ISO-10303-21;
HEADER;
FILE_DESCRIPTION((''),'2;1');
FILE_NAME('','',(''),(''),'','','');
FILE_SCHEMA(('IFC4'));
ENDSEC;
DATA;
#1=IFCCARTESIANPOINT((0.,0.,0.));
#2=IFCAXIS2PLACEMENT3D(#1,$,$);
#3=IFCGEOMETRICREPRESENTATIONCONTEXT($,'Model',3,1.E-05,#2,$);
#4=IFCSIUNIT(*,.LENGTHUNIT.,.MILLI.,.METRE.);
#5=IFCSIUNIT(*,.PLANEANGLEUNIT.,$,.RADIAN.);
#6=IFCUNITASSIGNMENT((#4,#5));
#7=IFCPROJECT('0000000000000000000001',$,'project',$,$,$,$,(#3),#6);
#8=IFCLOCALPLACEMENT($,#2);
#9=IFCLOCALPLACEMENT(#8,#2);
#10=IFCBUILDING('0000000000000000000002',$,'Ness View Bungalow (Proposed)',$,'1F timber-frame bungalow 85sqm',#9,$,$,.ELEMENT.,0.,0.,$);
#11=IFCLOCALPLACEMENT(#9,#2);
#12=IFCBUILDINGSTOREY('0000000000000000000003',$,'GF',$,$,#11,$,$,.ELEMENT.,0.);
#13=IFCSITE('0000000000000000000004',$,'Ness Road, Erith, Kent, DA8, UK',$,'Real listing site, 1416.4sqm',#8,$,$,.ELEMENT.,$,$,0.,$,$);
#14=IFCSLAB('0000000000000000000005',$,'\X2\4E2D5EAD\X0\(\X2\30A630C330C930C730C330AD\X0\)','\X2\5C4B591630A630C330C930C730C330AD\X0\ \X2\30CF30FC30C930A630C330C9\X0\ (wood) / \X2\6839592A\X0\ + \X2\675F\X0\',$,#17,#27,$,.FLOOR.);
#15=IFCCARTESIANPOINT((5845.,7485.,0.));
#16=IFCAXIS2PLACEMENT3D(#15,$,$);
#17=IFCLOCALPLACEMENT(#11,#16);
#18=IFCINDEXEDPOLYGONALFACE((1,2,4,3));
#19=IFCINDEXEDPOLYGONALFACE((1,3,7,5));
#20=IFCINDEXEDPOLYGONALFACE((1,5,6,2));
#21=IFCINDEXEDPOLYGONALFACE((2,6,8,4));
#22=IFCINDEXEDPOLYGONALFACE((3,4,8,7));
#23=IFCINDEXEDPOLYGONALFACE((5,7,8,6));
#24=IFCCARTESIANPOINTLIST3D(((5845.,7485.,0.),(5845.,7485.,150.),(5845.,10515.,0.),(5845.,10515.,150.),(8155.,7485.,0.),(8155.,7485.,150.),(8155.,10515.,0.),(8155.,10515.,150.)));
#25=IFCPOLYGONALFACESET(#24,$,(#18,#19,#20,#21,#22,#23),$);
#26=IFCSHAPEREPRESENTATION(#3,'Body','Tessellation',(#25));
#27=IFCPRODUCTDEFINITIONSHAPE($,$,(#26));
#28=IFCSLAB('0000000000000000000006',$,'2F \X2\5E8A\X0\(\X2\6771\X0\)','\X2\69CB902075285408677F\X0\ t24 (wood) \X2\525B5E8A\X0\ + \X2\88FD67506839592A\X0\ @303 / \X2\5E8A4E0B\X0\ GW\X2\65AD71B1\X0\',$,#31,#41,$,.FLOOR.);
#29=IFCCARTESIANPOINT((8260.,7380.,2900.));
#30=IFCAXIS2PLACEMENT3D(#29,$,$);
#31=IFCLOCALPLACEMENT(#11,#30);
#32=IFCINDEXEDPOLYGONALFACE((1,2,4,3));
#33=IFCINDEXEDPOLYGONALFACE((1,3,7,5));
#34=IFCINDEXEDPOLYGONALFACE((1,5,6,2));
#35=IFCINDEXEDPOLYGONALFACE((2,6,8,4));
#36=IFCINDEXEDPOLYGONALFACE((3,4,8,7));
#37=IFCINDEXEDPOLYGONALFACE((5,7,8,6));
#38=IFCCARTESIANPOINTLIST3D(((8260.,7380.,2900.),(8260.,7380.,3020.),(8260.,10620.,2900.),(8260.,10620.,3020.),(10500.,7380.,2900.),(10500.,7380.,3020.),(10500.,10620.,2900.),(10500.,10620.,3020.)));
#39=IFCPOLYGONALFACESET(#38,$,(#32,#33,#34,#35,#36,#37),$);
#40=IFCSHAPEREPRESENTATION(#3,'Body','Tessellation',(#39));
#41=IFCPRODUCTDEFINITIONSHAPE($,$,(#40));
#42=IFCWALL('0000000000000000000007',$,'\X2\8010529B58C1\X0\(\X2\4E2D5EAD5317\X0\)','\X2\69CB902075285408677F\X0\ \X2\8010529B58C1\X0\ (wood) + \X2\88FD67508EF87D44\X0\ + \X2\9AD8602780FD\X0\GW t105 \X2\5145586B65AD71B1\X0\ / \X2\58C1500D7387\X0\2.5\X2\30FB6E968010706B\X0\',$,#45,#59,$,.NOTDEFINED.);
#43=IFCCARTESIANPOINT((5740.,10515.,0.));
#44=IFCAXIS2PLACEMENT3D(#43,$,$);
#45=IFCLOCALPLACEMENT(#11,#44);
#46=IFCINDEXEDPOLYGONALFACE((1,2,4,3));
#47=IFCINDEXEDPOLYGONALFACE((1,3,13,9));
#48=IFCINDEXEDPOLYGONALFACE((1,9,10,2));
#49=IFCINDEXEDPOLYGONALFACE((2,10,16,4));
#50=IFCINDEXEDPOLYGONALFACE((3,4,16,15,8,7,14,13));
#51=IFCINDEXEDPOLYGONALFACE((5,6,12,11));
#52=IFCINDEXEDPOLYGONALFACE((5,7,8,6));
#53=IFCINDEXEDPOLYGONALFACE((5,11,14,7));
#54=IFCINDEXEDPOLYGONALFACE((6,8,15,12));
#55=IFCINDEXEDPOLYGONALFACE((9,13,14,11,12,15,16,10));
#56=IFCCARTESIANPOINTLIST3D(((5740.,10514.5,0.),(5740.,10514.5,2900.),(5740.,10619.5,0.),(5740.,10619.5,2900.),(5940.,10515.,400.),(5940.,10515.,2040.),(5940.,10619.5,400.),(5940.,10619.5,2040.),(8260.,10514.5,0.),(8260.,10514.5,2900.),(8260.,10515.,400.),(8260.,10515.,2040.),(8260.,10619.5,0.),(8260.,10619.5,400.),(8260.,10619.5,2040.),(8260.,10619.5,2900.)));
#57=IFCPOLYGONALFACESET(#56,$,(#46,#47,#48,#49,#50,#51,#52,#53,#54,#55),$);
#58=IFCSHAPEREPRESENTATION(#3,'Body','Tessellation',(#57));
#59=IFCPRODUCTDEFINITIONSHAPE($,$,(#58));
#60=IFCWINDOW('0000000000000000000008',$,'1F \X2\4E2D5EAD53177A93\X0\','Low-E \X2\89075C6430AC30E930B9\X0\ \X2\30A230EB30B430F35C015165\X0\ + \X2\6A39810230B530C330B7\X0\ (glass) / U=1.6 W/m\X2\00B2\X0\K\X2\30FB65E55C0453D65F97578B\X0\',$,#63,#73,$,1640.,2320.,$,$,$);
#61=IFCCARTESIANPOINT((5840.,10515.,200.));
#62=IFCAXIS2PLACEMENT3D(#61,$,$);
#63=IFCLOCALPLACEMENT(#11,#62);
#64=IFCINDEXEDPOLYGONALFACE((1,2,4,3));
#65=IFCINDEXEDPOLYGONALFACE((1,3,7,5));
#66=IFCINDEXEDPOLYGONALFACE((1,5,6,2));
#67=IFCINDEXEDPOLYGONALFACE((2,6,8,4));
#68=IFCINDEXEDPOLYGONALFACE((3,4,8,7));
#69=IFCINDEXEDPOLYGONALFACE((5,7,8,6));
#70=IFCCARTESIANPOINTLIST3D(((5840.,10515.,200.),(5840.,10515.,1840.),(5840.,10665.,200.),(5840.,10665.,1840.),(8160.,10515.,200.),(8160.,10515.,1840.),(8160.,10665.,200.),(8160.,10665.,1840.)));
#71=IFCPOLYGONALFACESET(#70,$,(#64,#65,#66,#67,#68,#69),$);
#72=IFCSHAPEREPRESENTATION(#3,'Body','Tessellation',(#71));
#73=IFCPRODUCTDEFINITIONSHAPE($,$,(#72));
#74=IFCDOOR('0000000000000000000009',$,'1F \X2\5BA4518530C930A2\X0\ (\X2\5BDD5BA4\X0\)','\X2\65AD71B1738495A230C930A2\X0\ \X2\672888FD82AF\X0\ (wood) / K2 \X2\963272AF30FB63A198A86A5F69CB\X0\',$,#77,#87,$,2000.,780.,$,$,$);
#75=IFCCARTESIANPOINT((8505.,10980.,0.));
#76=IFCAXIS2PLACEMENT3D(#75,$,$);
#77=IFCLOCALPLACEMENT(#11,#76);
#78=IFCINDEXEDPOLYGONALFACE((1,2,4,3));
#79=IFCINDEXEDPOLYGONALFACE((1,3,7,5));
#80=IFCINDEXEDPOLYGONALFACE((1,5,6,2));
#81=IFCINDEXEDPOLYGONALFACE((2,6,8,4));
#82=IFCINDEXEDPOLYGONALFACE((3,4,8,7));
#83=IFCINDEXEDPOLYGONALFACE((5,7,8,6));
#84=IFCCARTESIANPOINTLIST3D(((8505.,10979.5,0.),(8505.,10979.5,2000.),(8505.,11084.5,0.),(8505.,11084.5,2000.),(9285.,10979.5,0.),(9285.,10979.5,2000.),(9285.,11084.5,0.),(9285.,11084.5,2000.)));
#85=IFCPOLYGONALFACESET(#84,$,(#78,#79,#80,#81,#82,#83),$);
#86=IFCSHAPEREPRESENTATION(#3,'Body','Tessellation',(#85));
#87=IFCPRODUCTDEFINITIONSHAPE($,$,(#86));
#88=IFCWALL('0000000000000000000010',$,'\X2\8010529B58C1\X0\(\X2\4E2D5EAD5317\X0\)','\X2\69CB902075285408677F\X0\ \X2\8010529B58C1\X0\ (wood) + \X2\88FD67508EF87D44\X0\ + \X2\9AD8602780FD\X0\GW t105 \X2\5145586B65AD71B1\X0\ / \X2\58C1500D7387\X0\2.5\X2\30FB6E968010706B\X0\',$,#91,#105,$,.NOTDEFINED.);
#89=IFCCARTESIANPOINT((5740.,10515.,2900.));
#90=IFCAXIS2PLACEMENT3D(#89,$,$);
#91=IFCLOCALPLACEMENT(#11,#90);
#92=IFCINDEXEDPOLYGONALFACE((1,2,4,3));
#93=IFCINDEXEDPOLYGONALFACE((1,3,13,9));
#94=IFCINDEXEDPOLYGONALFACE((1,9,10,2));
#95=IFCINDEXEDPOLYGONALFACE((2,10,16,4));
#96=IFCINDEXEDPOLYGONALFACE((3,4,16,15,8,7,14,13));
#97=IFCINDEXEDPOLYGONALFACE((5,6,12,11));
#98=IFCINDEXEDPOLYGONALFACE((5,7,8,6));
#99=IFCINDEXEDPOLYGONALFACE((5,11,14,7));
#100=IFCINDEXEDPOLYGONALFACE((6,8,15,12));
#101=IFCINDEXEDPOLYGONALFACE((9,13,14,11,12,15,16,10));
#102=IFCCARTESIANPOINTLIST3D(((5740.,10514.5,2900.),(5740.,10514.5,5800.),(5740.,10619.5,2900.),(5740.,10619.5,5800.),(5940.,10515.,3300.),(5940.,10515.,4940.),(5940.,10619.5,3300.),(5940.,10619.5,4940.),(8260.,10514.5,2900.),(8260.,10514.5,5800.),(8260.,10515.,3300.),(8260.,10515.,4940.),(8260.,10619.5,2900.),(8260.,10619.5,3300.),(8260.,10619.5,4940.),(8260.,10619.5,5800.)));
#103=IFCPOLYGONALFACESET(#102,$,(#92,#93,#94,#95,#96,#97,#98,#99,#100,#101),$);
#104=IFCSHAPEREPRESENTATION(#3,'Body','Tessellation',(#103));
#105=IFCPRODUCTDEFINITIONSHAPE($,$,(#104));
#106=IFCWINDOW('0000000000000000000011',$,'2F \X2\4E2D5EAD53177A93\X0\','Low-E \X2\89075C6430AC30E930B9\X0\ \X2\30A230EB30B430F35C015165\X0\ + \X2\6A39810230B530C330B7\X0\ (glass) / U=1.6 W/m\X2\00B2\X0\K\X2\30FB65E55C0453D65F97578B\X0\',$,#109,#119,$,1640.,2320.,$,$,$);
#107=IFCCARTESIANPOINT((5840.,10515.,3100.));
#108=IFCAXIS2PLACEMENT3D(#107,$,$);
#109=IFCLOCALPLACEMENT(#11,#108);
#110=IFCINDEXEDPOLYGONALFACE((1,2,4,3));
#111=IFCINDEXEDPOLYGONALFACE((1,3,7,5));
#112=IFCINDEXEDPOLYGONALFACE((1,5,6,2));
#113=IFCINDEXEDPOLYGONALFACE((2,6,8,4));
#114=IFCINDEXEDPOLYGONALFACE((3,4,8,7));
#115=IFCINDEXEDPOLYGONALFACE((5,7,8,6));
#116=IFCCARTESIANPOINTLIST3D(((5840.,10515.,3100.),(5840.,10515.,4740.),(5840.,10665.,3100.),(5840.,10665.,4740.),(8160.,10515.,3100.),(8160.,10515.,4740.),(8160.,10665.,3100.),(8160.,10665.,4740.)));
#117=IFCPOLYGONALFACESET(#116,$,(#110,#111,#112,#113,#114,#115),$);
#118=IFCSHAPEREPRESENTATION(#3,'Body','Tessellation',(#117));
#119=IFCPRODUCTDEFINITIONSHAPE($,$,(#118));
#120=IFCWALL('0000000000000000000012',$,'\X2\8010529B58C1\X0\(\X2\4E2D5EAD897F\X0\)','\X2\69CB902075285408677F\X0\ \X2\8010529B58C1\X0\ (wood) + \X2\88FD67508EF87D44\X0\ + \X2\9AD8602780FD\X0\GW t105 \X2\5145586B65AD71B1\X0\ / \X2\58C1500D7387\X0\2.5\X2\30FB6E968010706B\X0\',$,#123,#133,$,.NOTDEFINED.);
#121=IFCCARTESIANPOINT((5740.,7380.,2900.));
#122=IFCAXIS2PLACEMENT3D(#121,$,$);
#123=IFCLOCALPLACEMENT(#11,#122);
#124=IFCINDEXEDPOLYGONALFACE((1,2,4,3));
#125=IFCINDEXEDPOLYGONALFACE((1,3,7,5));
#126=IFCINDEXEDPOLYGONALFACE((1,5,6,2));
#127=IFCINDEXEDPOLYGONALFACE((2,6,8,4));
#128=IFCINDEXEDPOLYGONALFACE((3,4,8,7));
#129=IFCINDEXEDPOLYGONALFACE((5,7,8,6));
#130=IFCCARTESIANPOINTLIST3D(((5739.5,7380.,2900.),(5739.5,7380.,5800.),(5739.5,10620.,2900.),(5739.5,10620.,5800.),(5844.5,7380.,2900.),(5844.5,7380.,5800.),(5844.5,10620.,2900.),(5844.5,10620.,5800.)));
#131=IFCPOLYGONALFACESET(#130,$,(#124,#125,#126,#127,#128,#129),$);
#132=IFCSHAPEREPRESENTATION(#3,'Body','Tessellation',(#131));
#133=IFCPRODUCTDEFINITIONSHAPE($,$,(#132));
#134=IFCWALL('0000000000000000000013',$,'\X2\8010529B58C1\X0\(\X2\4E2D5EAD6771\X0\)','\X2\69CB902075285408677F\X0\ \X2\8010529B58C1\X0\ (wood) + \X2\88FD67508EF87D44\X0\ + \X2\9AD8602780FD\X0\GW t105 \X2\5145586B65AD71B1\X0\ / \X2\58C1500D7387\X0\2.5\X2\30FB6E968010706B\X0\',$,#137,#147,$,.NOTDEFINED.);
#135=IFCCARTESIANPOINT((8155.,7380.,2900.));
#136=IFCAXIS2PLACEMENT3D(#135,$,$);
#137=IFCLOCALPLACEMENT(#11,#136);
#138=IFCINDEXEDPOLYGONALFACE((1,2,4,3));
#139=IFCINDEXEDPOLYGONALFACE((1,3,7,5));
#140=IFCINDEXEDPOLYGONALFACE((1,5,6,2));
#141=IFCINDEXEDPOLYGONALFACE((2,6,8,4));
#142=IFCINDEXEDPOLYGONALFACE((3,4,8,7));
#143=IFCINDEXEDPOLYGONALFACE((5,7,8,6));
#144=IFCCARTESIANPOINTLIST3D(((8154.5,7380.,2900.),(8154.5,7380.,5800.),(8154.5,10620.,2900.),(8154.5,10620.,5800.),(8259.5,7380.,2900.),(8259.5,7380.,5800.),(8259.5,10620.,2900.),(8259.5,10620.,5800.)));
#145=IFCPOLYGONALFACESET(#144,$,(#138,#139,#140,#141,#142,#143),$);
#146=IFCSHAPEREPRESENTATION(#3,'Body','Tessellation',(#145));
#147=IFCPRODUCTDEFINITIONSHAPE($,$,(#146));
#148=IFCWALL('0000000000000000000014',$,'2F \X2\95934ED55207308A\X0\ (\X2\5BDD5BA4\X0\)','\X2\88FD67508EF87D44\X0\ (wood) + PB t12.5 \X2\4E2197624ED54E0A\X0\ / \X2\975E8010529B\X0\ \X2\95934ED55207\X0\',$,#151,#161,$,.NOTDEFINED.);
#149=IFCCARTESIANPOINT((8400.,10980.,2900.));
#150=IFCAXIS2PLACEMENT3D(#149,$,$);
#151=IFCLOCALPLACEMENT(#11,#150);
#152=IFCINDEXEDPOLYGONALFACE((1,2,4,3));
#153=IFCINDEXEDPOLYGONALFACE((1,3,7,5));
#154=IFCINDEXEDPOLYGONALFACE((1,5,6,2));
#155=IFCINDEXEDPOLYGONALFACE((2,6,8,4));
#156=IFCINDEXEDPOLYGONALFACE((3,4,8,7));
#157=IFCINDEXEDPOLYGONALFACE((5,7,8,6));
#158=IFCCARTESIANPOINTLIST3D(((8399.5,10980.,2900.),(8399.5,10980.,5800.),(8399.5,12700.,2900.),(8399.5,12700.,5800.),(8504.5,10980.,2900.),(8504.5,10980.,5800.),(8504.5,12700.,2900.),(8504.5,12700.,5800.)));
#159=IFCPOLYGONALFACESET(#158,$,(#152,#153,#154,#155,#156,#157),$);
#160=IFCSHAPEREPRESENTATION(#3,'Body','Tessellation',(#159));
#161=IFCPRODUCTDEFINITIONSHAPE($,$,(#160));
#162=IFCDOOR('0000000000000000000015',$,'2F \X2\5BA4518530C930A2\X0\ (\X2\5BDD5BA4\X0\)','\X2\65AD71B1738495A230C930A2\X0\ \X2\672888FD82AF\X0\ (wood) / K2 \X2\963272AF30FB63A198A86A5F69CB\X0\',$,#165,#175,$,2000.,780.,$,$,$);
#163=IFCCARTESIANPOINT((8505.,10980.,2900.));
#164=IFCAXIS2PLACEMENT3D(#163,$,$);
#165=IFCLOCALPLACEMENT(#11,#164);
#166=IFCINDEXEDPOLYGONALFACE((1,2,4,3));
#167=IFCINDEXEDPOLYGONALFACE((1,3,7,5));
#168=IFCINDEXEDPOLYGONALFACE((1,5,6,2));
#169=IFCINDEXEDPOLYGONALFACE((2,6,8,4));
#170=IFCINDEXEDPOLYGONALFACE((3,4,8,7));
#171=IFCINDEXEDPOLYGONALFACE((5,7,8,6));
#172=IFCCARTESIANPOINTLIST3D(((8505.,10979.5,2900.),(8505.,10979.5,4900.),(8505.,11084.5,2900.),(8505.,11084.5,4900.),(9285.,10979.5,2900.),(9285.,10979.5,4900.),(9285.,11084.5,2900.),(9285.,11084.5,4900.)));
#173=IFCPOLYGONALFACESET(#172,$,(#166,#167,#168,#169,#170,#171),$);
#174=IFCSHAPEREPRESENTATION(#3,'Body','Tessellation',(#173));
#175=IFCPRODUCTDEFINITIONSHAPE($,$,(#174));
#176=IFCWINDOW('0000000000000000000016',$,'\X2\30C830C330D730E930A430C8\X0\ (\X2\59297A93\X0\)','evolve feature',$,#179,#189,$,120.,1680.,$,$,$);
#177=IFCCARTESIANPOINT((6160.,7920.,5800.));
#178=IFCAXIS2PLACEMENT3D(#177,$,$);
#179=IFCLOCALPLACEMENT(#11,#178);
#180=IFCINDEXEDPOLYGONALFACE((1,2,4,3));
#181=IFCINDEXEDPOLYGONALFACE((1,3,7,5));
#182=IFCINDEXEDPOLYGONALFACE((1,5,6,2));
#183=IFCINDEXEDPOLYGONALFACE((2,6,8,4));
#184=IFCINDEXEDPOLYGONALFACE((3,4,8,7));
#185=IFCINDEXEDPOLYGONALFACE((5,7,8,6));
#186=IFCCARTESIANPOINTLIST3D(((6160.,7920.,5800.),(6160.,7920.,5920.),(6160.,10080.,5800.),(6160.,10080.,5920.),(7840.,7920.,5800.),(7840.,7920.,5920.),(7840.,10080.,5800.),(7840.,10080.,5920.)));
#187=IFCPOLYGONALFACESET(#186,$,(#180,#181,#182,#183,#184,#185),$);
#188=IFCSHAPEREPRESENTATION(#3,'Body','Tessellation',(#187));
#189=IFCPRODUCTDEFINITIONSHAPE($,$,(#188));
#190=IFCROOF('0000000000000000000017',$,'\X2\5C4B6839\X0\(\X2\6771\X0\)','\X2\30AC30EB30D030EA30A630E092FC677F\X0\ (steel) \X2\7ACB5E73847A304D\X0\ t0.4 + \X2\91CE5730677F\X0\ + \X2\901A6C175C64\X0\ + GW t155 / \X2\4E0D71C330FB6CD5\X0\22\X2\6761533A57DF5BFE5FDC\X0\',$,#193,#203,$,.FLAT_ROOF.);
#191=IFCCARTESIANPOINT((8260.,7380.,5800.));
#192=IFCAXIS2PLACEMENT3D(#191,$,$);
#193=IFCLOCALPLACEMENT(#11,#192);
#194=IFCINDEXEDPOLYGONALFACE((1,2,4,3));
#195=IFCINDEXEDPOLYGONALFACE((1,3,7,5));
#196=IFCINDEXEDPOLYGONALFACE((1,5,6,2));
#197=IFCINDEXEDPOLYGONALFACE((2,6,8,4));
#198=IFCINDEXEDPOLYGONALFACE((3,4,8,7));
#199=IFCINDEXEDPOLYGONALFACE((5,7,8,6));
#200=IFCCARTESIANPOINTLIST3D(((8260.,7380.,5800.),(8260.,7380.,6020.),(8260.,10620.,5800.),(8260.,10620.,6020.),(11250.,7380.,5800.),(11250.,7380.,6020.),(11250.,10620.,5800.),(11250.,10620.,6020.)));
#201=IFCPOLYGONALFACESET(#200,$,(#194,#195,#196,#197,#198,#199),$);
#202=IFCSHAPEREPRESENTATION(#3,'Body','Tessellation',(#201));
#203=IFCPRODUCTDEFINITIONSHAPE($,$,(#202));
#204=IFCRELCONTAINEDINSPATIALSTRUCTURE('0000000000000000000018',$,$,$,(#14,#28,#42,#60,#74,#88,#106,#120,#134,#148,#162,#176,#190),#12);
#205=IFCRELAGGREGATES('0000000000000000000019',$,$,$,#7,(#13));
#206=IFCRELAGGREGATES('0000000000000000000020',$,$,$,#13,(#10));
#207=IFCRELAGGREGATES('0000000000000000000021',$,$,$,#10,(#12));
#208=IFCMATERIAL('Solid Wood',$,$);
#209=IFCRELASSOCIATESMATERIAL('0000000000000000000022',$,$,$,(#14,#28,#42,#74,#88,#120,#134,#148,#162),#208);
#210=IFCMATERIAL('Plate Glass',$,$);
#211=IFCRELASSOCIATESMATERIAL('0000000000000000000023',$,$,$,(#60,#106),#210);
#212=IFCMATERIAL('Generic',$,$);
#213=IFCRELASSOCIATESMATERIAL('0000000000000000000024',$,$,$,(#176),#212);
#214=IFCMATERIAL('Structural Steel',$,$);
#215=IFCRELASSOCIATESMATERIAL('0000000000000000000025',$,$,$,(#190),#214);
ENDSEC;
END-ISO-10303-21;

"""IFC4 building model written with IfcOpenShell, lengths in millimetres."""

from ifc_helpers import new_model, si_unit, frame, frame_2d, origin, place, context, project, spatial, rectangle, extrude, material, element, fill, save


model = new_model("IFC4")

# Units and contexts
model_context = context("Model", 3, precision=1e-05, world=origin())
ifc_project = project(units=[si_unit("LENGTHUNIT", "METRE", prefix="MILLI"), si_unit("PLANEANGLEUNIT", "RADIAN")], contexts=[model_context])

# Site, building, storey
site_placement = place(None, origin())
site = spatial("IfcSite", under=ifc_project, at=site_placement, Name="Ness Road, Erith, Kent, DA8, UK", ObjectType="Real listing site, 1416.4sqm", CompositionType="ELEMENT", RefElevation=0.0)
building_placement = place(site_placement, origin())
building = spatial("IfcBuilding", under=site, at=building_placement, Name="Ness View Bungalow (Proposed)", ObjectType="1F timber-frame bungalow 85sqm", CompositionType="ELEMENT", ElevationOfRefHeight=0.0, ElevationOfTerrain=0.0)
storey_placement = place(building_placement, origin())
storey = spatial("IfcBuildingStorey", under=building, at=storey_placement, Name="GF", CompositionType="ELEMENT", Elevation=0.0)

# Slabs
ifc_material_1 = material(Name="Solid Wood")
slab_1_placement = place(storey_placement, frame((5845.0, 7485.0, 0.0)))
element("IfcSlab", 1, at=slab_1_placement, inside=storey, material=ifc_material_1, Name="中庭(ウッドデッキ)", Description="屋外ウッドデッキ ハードウッド (wood) / 根太 + 束", PredefinedType="FLOOR", context=model_context, shape_type="SweptSolid", body=[
    extrude(rectangle(XDim=2310.0, YDim=3030.0, at=frame_2d((1155.0, 1515.0))), frame((5845.0, 7485.0, 0.0)), (0.0, 0.0, 1.0), 150.0),
])
slab_2_placement = place(storey_placement, frame((8260.0, 7380.0, 2900.0)))
element("IfcSlab", 2, at=slab_2_placement, inside=storey, material=ifc_material_1, Name="2F 床(東)", Description="構造用合板 t24 (wood) 剛床 + 製材根太 @303 / 床下 GW断熱", PredefinedType="FLOOR", context=model_context, shape_type="SweptSolid", body=[
    extrude(rectangle(XDim=2240.0, YDim=3240.0, at=frame_2d((1120.0, 1620.0))), frame((8260.0, 7380.0, 2900.0)), (0.0, 0.0, 1.0), 120.0),
])

# Wall, opening, window
wall_1_placement = place(storey_placement, frame((5740.0, 10515.0, 0.0)))
wall_1 = element("IfcWall", 3, at=wall_1_placement, inside=storey, material=ifc_material_1, Name="耐力壁(中庭北)", Description="構造用合板 耐力壁 (wood) + 製材軸組 + 高性能GW t105 充填断熱 / 壁倍率2.5・準耐火", PredefinedType="NOTDEFINED", context=model_context, shape_type="SweptSolid", body=[
    extrude(rectangle(XDim=2520.0, YDim=105.0, at=frame_2d((1260.0, 52.0))), frame((5740.0, 10515.0, 0.0)), (0.0, 0.0, 1.0), 2900.0),
])
opening_1_placement = place(storey_placement, frame((5840.0, 10515.0, 200.0)))
opening_1 = element("IfcOpeningElement", 4, at=opening_1_placement, cuts=wall_1, PredefinedType="NOTDEFINED", context=model_context, shape_type="SweptSolid", body=[
    extrude(rectangle(XDim=2320.0, YDim=150.0, at=frame_2d((1160.0, 75.0))), frame((5840.0, 10515.0, 200.0)), (0.0, 0.0, 1.0), 1640.0),
])
ifc_material_2 = material(Name="Plate Glass")
window_1_placement = place(storey_placement, frame((5840.0, 10515.0, 200.0)))
window_1 = element("IfcWindow", 5, at=window_1_placement, inside=storey, material=ifc_material_2, Name="1F 中庭北窓", Description="Low-E 複層ガラス アルゴン封入 + 樹脂サッシ (glass) / U=1.6 W/m²K・日射取得型", OverallHeight=1640.0, OverallWidth=2320.0, context=model_context, shape_type="SweptSolid", body=[
    extrude(rectangle(XDim=2320.0, YDim=150.0, at=frame_2d((1160.0, 75.0))), frame((5840.0, 10515.0, 200.0)), (0.0, 0.0, 1.0), 1640.0),
])
fill(opening_1, window_1)

# Door
door_1_placement = place(storey_placement, frame((8505.0, 10980.0, 0.0)))
element("IfcDoor", 6, at=door_1_placement, inside=storey, material=ifc_material_1, Name="1F 室内ドア (寝室)", Description="断熱玄関ドア 木製芯 (wood) / K2 防犯・採風機構", OverallHeight=2000.0, OverallWidth=780.0, context=model_context, shape_type="SweptSolid", body=[
    extrude(rectangle(XDim=780.0, YDim=105.0, at=frame_2d((390.0, 52.0))), frame((8505.0, 10980.0, 0.0)), (0.0, 0.0, 1.0), 2000.0),
])

# Wall, opening, window
wall_2_placement = place(storey_placement, frame((5740.0, 10515.0, 2900.0)))
wall_2 = element("IfcWall", 7, at=wall_2_placement, inside=storey, material=ifc_material_1, Name="耐力壁(中庭北)", Description="構造用合板 耐力壁 (wood) + 製材軸組 + 高性能GW t105 充填断熱 / 壁倍率2.5・準耐火", PredefinedType="NOTDEFINED", context=model_context, shape_type="SweptSolid", body=[
    extrude(rectangle(XDim=2520.0, YDim=105.0, at=frame_2d((1260.0, 52.0))), frame((5740.0, 10515.0, 2900.0)), (0.0, 0.0, 1.0), 2900.0),
])
opening_2_placement = place(storey_placement, frame((5840.0, 10515.0, 3100.0)))
opening_2 = element("IfcOpeningElement", 8, at=opening_2_placement, cuts=wall_2, PredefinedType="NOTDEFINED", context=model_context, shape_type="SweptSolid", body=[
    extrude(rectangle(XDim=2320.0, YDim=150.0, at=frame_2d((1160.0, 75.0))), frame((5840.0, 10515.0, 3100.0)), (0.0, 0.0, 1.0), 1640.0),
])
window_2_placement = place(storey_placement, frame((5840.0, 10515.0, 3100.0)))
window_2 = element("IfcWindow", 9, at=window_2_placement, inside=storey, material=ifc_material_2, Name="2F 中庭北窓", Description="Low-E 複層ガラス アルゴン封入 + 樹脂サッシ (glass) / U=1.6 W/m²K・日射取得型", OverallHeight=1640.0, OverallWidth=2320.0, context=model_context, shape_type="SweptSolid", body=[
    extrude(rectangle(XDim=2320.0, YDim=150.0, at=frame_2d((1160.0, 75.0))), frame((5840.0, 10515.0, 3100.0)), (0.0, 0.0, 1.0), 1640.0),
])
fill(opening_2, window_2)

# Walls
wall_3_placement = place(storey_placement, frame((5740.0, 7380.0, 2900.0)))
element("IfcWall", 10, at=wall_3_placement, inside=storey, material=ifc_material_1, Name="耐力壁(中庭西)", Description="構造用合板 耐力壁 (wood) + 製材軸組 + 高性能GW t105 充填断熱 / 壁倍率2.5・準耐火", PredefinedType="NOTDEFINED", context=model_context, shape_type="SweptSolid", body=[
    extrude(rectangle(XDim=105.0, YDim=3240.0, at=frame_2d((52.0, 1620.0))), frame((5740.0, 7380.0, 2900.0)), (0.0, 0.0, 1.0), 2900.0),
])
wall_4_placement = place(storey_placement, frame((8155.0, 7380.0, 2900.0)))
element("IfcWall", 11, at=wall_4_placement, inside=storey, material=ifc_material_1, Name="耐力壁(中庭東)", Description="構造用合板 耐力壁 (wood) + 製材軸組 + 高性能GW t105 充填断熱 / 壁倍率2.5・準耐火", PredefinedType="NOTDEFINED", context=model_context, shape_type="SweptSolid", body=[
    extrude(rectangle(XDim=105.0, YDim=3240.0, at=frame_2d((52.0, 1620.0))), frame((8155.0, 7380.0, 2900.0)), (0.0, 0.0, 1.0), 2900.0),
])
wall_5_placement = place(storey_placement, frame((8400.0, 10980.0, 2900.0)))
element("IfcWall", 12, at=wall_5_placement, inside=storey, material=ifc_material_1, Name="2F 間仕切り (寝室)", Description="製材軸組 (wood) + PB t12.5 両面仕上 / 非耐力 間仕切", PredefinedType="NOTDEFINED", context=model_context, shape_type="SweptSolid", body=[
    extrude(rectangle(XDim=105.0, YDim=1720.0, at=frame_2d((52.0, 860.0))), frame((8400.0, 10980.0, 2900.0)), (0.0, 0.0, 1.0), 2900.0),
])

# Door
door_2_placement = place(storey_placement, frame((8505.0, 10980.0, 2900.0)))
element("IfcDoor", 13, at=door_2_placement, inside=storey, material=ifc_material_1, Name="2F 室内ドア (寝室)", Description="断熱玄関ドア 木製芯 (wood) / K2 防犯・採風機構", OverallHeight=2000.0, OverallWidth=780.0, context=model_context, shape_type="SweptSolid", body=[
    extrude(rectangle(XDim=780.0, YDim=105.0, at=frame_2d((390.0, 52.0))), frame((8505.0, 10980.0, 2900.0)), (0.0, 0.0, 1.0), 2000.0),
])

# Window
ifc_material_3 = material(Name="Generic")
window_3_placement = place(storey_placement, frame((6160.0, 7920.0, 5800.0)))
element("IfcWindow", 14, at=window_3_placement, inside=storey, material=ifc_material_3, Name="トップライト (天窓)", Description="evolve feature", OverallHeight=120.0, OverallWidth=1680.0, context=model_context, shape_type="SweptSolid", body=[
    extrude(rectangle(XDim=1680.0, YDim=2160.0, at=frame_2d((840.0, 1080.0))), frame((6160.0, 7920.0, 5800.0)), (0.0, 0.0, 1.0), 120.0),
])

# Roof
ifc_material_4 = material(Name="Structural Steel")
roof_placement = place(storey_placement, frame((8260.0, 7380.0, 5800.0)))
element("IfcRoof", 15, at=roof_placement, inside=storey, material=ifc_material_4, Name="屋根(東)", Description="ガルバリウム鋼板 (steel) 立平葺き t0.4 + 野地板 + 通気層 + GW t155 / 不燃・法22条区域対応", PredefinedType="FLAT_ROOF", context=model_context, shape_type="SweptSolid", body=[
    extrude(rectangle(XDim=2990.0, YDim=3240.0, at=frame_2d((1495.0, 1620.0))), frame((8260.0, 7380.0, 5800.0)), (0.0, 0.0, 1.0), 220.0),
])

save(model, "model.ifc")
